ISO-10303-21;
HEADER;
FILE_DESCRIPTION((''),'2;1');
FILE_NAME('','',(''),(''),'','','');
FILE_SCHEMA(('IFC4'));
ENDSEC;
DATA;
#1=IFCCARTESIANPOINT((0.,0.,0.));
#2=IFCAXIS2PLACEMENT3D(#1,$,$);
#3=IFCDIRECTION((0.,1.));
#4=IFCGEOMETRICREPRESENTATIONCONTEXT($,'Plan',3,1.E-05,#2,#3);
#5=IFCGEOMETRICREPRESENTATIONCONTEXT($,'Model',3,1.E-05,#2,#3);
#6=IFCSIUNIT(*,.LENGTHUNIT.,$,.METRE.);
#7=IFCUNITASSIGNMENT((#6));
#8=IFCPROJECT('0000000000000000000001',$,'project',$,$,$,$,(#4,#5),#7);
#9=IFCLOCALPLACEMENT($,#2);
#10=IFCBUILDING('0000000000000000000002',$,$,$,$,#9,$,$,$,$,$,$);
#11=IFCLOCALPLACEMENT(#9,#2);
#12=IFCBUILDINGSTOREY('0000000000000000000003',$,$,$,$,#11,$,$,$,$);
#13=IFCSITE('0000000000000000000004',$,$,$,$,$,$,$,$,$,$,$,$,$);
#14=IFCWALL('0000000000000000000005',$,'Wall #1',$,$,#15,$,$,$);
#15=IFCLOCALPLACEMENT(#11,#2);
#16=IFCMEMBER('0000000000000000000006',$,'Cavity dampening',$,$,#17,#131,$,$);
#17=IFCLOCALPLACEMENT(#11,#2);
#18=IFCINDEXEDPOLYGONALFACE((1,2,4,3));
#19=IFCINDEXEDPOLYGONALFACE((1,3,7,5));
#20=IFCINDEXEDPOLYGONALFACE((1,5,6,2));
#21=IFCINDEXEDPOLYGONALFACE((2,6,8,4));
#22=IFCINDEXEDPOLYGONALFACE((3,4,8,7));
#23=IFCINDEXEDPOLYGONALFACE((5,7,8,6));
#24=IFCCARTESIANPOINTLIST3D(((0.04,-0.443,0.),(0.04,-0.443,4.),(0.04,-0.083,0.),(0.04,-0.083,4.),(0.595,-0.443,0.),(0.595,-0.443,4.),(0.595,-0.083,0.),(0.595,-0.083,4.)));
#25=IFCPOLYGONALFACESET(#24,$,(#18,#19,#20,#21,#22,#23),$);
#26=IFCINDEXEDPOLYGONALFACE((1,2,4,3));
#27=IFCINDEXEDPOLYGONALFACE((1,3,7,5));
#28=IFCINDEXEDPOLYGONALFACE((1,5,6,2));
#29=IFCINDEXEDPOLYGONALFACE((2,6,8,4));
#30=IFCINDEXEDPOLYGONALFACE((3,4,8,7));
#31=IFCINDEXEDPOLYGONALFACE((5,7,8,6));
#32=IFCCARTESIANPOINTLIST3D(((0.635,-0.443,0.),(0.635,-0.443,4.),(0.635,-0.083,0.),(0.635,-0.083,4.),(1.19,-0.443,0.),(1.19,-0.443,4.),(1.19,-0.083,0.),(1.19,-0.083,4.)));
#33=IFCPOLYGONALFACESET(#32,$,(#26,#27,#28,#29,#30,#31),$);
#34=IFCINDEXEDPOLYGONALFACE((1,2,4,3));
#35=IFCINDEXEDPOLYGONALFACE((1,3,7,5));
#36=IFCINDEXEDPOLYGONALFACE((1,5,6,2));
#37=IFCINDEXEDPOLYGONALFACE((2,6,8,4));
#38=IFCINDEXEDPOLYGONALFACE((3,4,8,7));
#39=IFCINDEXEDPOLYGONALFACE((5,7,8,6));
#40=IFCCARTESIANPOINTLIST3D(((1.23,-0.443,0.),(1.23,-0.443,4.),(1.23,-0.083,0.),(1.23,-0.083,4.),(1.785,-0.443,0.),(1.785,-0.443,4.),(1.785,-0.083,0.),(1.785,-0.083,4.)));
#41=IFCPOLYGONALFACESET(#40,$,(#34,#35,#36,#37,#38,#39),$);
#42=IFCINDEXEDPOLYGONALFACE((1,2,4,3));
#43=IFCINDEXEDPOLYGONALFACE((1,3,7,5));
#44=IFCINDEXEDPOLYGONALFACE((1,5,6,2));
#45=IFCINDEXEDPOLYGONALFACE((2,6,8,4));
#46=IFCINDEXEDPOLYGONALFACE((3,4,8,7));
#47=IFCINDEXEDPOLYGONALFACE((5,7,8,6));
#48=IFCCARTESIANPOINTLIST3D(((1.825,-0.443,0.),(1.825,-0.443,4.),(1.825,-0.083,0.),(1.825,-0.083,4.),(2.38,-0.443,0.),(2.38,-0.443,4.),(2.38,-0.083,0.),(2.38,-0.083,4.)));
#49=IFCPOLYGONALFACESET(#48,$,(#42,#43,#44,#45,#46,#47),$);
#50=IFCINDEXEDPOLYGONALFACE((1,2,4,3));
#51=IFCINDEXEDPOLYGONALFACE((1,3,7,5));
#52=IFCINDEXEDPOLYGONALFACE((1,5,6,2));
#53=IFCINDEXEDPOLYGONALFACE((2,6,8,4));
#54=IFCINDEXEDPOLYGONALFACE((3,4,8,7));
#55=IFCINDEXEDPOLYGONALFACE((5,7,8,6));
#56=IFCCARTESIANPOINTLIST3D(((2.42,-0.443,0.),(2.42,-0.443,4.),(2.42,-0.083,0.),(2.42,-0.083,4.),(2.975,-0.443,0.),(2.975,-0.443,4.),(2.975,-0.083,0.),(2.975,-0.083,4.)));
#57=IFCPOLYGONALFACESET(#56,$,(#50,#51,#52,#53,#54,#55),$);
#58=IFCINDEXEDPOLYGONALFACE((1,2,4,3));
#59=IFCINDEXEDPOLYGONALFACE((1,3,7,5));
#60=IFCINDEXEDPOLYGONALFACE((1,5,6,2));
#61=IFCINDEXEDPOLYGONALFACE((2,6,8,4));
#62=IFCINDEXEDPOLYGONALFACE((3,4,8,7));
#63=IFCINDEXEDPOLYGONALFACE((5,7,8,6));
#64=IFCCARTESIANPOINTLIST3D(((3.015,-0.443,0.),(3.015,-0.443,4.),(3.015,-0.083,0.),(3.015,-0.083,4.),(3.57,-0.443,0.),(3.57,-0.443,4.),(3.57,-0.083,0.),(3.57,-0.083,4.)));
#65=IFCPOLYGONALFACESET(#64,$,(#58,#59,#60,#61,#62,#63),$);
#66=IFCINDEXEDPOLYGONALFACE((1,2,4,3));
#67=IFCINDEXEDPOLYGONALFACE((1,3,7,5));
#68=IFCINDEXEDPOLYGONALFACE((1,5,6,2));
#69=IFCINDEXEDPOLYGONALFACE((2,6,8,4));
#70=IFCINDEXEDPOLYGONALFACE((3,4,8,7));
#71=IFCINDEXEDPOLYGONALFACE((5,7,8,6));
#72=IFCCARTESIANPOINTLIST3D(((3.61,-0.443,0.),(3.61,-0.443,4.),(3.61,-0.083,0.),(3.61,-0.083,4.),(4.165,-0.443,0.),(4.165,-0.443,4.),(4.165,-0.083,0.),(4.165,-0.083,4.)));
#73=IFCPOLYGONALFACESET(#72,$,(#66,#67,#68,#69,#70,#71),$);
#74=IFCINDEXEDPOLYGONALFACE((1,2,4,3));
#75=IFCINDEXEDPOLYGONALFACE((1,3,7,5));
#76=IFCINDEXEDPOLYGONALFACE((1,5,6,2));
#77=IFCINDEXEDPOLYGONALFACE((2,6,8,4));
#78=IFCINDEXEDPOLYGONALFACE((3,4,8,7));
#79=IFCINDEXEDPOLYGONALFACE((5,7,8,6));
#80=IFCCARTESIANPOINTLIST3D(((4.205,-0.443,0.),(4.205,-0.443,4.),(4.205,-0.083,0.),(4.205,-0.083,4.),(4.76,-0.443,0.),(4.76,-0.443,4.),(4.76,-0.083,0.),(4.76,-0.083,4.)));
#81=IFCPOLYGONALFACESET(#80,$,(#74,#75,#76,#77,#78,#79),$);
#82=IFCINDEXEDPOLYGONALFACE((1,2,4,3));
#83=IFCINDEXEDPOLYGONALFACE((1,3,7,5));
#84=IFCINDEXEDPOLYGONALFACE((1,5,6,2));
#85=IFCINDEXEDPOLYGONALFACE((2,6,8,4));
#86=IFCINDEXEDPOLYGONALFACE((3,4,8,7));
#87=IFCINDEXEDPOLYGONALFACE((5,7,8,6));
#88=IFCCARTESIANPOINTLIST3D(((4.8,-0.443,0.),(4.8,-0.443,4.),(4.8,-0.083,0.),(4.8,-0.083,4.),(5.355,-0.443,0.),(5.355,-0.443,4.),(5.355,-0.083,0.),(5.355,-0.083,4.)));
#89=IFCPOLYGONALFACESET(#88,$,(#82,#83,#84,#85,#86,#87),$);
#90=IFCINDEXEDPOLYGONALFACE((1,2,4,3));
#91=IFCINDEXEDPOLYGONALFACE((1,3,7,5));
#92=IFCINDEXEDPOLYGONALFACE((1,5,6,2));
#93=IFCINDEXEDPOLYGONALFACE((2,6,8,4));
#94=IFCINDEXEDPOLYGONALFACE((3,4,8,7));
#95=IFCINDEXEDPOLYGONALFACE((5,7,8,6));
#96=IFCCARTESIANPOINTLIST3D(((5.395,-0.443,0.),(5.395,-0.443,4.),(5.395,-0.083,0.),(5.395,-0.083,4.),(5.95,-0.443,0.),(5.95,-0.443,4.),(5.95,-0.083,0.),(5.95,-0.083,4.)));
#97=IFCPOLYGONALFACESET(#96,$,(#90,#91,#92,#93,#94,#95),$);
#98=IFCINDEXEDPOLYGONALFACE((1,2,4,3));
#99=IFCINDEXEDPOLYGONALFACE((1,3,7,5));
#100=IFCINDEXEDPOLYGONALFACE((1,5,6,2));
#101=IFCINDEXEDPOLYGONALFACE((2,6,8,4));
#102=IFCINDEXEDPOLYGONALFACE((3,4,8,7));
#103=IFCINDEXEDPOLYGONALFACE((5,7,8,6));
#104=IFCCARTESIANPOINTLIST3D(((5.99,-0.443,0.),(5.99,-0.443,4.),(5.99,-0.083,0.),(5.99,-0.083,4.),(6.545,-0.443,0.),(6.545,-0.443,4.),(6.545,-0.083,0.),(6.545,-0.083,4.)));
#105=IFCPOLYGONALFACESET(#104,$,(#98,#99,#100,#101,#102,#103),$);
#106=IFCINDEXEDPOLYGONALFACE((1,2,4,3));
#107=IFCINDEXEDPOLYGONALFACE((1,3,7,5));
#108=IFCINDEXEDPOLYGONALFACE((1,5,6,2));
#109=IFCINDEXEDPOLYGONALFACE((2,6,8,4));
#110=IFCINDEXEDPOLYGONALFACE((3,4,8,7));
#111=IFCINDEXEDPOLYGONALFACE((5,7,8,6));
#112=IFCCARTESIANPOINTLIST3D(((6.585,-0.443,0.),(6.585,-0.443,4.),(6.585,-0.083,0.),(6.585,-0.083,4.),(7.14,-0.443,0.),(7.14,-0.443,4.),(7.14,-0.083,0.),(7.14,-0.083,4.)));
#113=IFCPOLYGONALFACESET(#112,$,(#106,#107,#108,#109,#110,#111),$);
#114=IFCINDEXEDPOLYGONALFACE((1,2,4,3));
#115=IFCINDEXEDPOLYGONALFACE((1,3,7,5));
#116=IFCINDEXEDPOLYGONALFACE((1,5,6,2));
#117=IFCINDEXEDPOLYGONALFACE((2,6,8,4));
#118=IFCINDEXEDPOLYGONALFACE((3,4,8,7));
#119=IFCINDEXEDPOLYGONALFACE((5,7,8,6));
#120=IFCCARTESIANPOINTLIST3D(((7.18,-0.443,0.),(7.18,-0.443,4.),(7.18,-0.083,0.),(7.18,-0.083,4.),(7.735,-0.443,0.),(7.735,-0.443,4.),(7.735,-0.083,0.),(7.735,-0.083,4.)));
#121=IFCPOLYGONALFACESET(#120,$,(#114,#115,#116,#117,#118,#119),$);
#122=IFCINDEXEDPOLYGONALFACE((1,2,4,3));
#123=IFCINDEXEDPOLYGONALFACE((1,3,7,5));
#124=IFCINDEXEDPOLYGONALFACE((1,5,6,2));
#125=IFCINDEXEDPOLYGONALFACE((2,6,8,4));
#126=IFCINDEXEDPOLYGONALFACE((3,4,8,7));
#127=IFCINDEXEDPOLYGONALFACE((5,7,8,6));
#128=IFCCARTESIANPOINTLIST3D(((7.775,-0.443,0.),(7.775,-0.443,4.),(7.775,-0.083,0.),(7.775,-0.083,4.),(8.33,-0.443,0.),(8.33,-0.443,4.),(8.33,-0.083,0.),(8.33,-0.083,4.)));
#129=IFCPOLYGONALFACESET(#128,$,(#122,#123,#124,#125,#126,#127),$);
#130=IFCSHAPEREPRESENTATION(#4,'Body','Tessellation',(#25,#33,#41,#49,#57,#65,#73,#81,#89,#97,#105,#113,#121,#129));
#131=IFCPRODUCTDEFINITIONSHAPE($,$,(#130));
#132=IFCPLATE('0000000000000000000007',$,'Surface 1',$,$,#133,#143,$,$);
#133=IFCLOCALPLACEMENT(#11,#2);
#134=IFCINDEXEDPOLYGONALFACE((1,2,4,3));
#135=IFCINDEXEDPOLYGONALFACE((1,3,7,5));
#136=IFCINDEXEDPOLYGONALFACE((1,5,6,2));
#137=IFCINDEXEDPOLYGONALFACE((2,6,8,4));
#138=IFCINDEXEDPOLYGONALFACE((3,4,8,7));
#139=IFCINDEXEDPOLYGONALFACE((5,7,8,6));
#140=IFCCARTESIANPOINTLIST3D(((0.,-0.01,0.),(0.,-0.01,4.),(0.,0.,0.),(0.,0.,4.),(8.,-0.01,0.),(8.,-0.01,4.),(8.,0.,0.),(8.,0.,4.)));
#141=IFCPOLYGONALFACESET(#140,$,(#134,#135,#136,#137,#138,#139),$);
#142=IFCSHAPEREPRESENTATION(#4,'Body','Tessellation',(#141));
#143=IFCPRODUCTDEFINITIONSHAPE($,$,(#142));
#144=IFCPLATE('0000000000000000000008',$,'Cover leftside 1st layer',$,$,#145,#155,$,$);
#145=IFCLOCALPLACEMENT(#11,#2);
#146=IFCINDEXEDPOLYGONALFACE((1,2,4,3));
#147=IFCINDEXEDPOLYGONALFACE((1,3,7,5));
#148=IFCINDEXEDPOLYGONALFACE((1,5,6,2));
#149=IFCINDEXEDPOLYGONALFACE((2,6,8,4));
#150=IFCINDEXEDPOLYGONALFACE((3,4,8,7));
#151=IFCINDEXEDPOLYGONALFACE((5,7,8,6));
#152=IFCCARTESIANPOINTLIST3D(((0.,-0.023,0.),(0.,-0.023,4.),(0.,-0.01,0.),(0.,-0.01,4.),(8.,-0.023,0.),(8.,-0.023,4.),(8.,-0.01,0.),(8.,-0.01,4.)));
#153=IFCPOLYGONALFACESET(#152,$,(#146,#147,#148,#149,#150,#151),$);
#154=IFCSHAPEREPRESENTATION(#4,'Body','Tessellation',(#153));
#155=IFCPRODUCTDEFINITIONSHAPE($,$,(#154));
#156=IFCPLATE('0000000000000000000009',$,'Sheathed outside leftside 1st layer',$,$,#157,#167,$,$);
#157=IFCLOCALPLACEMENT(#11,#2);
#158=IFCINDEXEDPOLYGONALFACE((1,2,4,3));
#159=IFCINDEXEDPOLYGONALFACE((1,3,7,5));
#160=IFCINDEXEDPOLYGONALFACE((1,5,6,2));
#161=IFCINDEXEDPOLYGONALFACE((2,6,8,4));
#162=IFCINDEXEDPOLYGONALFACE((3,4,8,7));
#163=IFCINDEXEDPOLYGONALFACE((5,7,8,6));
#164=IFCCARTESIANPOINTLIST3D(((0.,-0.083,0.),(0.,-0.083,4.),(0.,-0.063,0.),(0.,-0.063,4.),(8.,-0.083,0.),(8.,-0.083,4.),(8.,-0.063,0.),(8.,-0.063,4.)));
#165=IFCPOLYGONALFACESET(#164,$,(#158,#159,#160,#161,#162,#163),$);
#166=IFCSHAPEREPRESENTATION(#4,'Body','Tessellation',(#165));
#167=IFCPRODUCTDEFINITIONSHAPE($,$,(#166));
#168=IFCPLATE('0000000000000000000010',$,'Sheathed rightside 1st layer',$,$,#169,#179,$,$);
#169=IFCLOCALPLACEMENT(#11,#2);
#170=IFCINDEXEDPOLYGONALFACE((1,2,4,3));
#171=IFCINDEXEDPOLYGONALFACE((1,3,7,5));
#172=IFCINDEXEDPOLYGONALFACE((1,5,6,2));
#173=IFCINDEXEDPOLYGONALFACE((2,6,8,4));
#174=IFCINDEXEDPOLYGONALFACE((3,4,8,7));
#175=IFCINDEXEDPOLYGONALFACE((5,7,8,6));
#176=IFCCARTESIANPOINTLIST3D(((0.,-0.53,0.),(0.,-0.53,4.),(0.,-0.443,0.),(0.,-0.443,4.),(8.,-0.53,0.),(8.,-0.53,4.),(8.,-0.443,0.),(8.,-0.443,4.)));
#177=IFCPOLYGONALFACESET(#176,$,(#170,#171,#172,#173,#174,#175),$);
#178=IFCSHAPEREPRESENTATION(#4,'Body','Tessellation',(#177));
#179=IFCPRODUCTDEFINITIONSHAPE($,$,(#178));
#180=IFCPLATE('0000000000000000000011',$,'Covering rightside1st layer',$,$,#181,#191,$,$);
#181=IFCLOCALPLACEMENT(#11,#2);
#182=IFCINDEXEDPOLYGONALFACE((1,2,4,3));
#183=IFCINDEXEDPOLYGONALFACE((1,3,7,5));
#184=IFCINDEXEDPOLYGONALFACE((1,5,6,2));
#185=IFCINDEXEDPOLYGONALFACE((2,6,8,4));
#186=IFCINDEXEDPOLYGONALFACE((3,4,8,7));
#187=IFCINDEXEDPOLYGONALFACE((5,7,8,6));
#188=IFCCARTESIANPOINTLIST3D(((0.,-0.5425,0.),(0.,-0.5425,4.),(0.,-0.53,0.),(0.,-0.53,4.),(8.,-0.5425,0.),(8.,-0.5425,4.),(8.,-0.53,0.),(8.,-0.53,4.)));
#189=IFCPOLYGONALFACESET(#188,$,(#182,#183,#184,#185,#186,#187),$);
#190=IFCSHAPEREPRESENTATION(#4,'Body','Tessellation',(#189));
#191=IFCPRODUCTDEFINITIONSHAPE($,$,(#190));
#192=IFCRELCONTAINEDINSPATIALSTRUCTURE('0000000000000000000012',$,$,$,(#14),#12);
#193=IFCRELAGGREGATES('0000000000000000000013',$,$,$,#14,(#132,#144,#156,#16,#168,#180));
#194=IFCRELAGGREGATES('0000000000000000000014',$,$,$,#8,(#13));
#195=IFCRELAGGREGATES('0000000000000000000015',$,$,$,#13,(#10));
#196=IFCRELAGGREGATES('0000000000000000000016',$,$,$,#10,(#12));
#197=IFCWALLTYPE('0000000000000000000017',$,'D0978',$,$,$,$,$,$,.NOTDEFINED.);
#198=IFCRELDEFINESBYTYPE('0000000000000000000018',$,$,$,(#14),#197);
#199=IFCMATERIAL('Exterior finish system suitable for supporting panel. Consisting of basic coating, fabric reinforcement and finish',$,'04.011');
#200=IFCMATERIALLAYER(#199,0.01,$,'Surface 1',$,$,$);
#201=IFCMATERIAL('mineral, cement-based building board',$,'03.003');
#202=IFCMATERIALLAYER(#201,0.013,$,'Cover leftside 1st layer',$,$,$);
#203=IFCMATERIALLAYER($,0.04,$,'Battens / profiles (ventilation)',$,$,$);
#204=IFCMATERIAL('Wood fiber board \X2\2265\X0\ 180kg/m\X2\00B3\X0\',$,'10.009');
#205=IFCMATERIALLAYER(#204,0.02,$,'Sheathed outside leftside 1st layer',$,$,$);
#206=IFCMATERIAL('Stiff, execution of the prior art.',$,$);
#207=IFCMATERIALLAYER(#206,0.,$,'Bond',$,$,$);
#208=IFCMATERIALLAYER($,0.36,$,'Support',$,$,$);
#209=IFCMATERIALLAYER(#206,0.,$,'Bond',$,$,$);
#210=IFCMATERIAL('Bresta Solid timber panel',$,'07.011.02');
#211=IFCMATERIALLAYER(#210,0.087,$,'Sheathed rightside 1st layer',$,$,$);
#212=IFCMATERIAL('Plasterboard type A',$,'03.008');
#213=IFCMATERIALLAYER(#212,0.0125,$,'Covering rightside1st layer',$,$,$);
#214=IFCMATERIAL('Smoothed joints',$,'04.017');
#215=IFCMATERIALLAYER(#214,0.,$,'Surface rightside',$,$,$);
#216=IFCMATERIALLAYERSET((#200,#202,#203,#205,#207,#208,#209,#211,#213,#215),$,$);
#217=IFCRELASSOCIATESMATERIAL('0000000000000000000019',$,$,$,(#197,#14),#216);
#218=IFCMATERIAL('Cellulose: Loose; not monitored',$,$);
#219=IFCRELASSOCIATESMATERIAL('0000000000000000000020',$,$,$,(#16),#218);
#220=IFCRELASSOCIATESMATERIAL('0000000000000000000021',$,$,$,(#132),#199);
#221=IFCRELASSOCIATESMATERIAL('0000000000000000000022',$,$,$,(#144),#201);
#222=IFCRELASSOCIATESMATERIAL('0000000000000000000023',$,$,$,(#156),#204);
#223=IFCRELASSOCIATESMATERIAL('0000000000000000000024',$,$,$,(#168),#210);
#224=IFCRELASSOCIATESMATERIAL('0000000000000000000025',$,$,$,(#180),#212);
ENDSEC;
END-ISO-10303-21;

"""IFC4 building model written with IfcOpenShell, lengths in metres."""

from ifc_helpers import new_model, si_unit, direction, frame, frame_2d, origin, origin_with_axes, place, context, project, spatial, rectangle, extrude, material, layer, layer_set, type_object, element, aggregate, save


model = new_model("IFC4")

# Units and contexts
plan_context = context("Plan", 3, precision=1e-05, world=origin(), true_north=direction((0.0, 1.0)))
model_context = context("Model", 3, precision=1e-05, world=origin(), true_north=direction((0.0, 1.0)))
ifc_project = project(units=[si_unit("LENGTHUNIT", "METRE")], contexts=[plan_context, model_context])

# Site, building, storey
site = spatial("IfcSite", under=ifc_project)
building_placement = place(None, origin())
building = spatial("IfcBuilding", under=site, at=building_placement)
storey_placement = place(building_placement, origin())
storey = spatial("IfcBuildingStorey", under=building, at=storey_placement)

# Wall, member, plates
ifc_material_1 = material(Name="Exterior finish system suitable for supporting panel. Consisting of basic coating, fabric reinforcement and finish", Category="04.011")
ifc_layer_1 = layer(ifc_material_1, 0.01, Name="Surface 1")
ifc_material_2 = material(Name="mineral, cement-based building board", Category="03.003")
ifc_layer_2 = layer(ifc_material_2, 0.013, Name="Cover leftside 1st layer")
ifc_layer_3 = layer(None, 0.04, Name="Battens / profiles (ventilation)")
ifc_material_3 = material(Name="Wood fiber board ≥ 180kg/m³", Category="10.009")
ifc_layer_4 = layer(ifc_material_3, 0.02, Name="Sheathed outside leftside 1st layer")
ifc_material_4 = material(Name="Stiff, execution of the prior art.")
ifc_layer_5 = layer(ifc_material_4, 0.0, Name="Bond")
ifc_layer_6 = layer(None, 0.36, Name="Support")
ifc_layer_7 = layer(ifc_material_4, 0.0, Name="Bond")
ifc_material_5 = material(Name="Bresta Solid timber panel", Category="07.011.02")
ifc_layer_8 = layer(ifc_material_5, 0.087, Name="Sheathed rightside 1st layer")
ifc_material_6 = material(Name="Plasterboard type A", Category="03.008")
ifc_layer_9 = layer(ifc_material_6, 0.0125, Name="Covering rightside1st layer")
ifc_material_7 = material(Name="Smoothed joints", Category="04.017")
ifc_layer_10 = layer(ifc_material_7, 0.0, Name="Surface rightside")
ifc_layer_set = layer_set([ifc_layer_1, ifc_layer_2, ifc_layer_3, ifc_layer_4, ifc_layer_5, ifc_layer_6, ifc_layer_7, ifc_layer_8, ifc_layer_9, ifc_layer_10])
wall_type = type_object("IfcWallType", Name="D0978", PredefinedType="NOTDEFINED", material=ifc_layer_set)
wall_placement = place(None, frame((0.0, 0.0, 0.0), z_axis=(0.0, -1.0, 0.0), x_axis=(1.0, 0.0, 0.0)))
wall = element("IfcWall", 1, at=wall_placement, inside=storey, type_object=wall_type, material=ifc_layer_set, Name="Wall #1")
ifc_material_8 = material(Name="Cellulose: Loose; not monitored")
member_1_placement = place(wall_placement, origin())
member_1 = element("IfcMember", 2, at=member_1_placement, material=ifc_material_8, Name="Cavity dampening", context=plan_context, shape_type="SweptSolid", body=[
    extrude(rectangle(XDim=0.555, YDim=0.36, at=frame_2d((0.2775, 0.18), x_axis=(1.0, 0.0))), frame((0.04, 4.0, 0.083), z_axis=(0.0, -1.0, 0.0), x_axis=(1.0, 0.0, 0.0)), (0.0, 0.0, 1.0), 4.0),
    extrude(rectangle(XDim=0.555, YDim=0.36, at=frame_2d((0.2775, 0.18), x_axis=(1.0, 0.0))), frame((0.635, 4.0, 0.083), z_axis=(0.0, -1.0, 0.0), x_axis=(1.0, 0.0, 0.0)), (0.0, 0.0, 1.0), 4.0),
    extrude(rectangle(XDim=0.555, YDim=0.36, at=frame_2d((0.2775, 0.18), x_axis=(1.0, 0.0))), frame((1.23, 4.0, 0.083), z_axis=(0.0, -1.0, 0.0), x_axis=(1.0, 0.0, 0.0)), (0.0, 0.0, 1.0), 4.0),
    extrude(rectangle(XDim=0.555, YDim=0.36, at=frame_2d((0.2775, 0.18), x_axis=(1.0, 0.0))), frame((1.825, 4.0, 0.083), z_axis=(0.0, -1.0, 0.0), x_axis=(1.0, 0.0, 0.0)), (0.0, 0.0, 1.0), 4.0),
    extrude(rectangle(XDim=0.555, YDim=0.36, at=frame_2d((0.2775, 0.18), x_axis=(1.0, 0.0))), frame((2.42, 4.0, 0.083), z_axis=(0.0, -1.0, 0.0), x_axis=(1.0, 0.0, 0.0)), (0.0, 0.0, 1.0), 4.0),
    extrude(rectangle(XDim=0.555, YDim=0.36, at=frame_2d((0.2775, 0.18), x_axis=(1.0, 0.0))), frame((3.015, 4.0, 0.083), z_axis=(0.0, -1.0, 0.0), x_axis=(1.0, 0.0, 0.0)), (0.0, 0.0, 1.0), 4.0),
    extrude(rectangle(XDim=0.555, YDim=0.36, at=frame_2d((0.2775, 0.18), x_axis=(1.0, 0.0))), frame((3.61, 4.0, 0.083), z_axis=(0.0, -1.0, 0.0), x_axis=(1.0, 0.0, 0.0)), (0.0, 0.0, 1.0), 4.0),
    extrude(rectangle(XDim=0.555, YDim=0.36, at=frame_2d((0.2775, 0.18), x_axis=(1.0, 0.0))), frame((4.205, 4.0, 0.083), z_axis=(0.0, -1.0, 0.0), x_axis=(1.0, 0.0, 0.0)), (0.0, 0.0, 1.0), 4.0),
    extrude(rectangle(XDim=0.555, YDim=0.36, at=frame_2d((0.2775, 0.18), x_axis=(1.0, 0.0))), frame((4.8, 4.0, 0.083), z_axis=(0.0, -1.0, 0.0), x_axis=(1.0, 0.0, 0.0)), (0.0, 0.0, 1.0), 4.0),
    extrude(rectangle(XDim=0.555, YDim=0.36, at=frame_2d((0.2775, 0.18), x_axis=(1.0, 0.0))), frame((5.395, 4.0, 0.083), z_axis=(0.0, -1.0, 0.0), x_axis=(1.0, 0.0, 0.0)), (0.0, 0.0, 1.0), 4.0),
    extrude(rectangle(XDim=0.555, YDim=0.36, at=frame_2d((0.2775, 0.18), x_axis=(1.0, 0.0))), frame((5.99, 4.0, 0.083), z_axis=(0.0, -1.0, 0.0), x_axis=(1.0, 0.0, 0.0)), (0.0, 0.0, 1.0), 4.0),
    extrude(rectangle(XDim=0.555, YDim=0.36, at=frame_2d((0.2775, 0.18), x_axis=(1.0, 0.0))), frame((6.585, 4.0, 0.083), z_axis=(0.0, -1.0, 0.0), x_axis=(1.0, 0.0, 0.0)), (0.0, 0.0, 1.0), 4.0),
    extrude(rectangle(XDim=0.555, YDim=0.36, at=frame_2d((0.2775, 0.18), x_axis=(1.0, 0.0))), frame((7.18, 4.0, 0.083), z_axis=(0.0, -1.0, 0.0), x_axis=(1.0, 0.0, 0.0)), (0.0, 0.0, 1.0), 4.0),
    extrude(rectangle(XDim=0.555, YDim=0.36, at=frame_2d((0.2775, 0.18), x_axis=(1.0, 0.0))), frame((7.775, 4.0, 0.083), z_axis=(0.0, -1.0, 0.0), x_axis=(1.0, 0.0, 0.0)), (0.0, 0.0, 1.0), 4.0),
])
plate_1_placement = place(wall_placement, origin())
plate_1 = element("IfcPlate", 3, at=plate_1_placement, material=ifc_material_1, Name="Surface 1", context=plan_context, shape_type="SweptSolid", body=[
    extrude(rectangle(XDim=8.0, YDim=4.0, at=frame_2d((4.0, 2.0), x_axis=(1.0, 0.0))), origin_with_axes(), (0.0, 0.0, 1.0), 0.01),
])
plate_2_placement = place(wall_placement, origin())
plate_2 = element("IfcPlate", 4, at=plate_2_placement, material=ifc_material_2, Name="Cover leftside 1st layer", context=plan_context, shape_type="SweptSolid", body=[
    extrude(rectangle(XDim=8.0, YDim=4.0, at=frame_2d((4.0, 2.0), x_axis=(1.0, 0.0))), frame((0.0, 0.0, 0.01), z_axis=(0.0, 0.0, 1.0), x_axis=(1.0, 0.0, 0.0)), (0.0, 0.0, 1.0), 0.013),
])
plate_3_placement = place(wall_placement, origin())
plate_3 = element("IfcPlate", 5, at=plate_3_placement, material=ifc_material_3, Name="Sheathed outside leftside 1st layer", context=plan_context, shape_type="SweptSolid", body=[
    extrude(rectangle(XDim=8.0, YDim=4.0, at=frame_2d((4.0, 2.0), x_axis=(1.0, 0.0))), frame((0.0, 0.0, 0.063), z_axis=(0.0, 0.0, 1.0), x_axis=(1.0, 0.0, 0.0)), (0.0, 0.0, 1.0), 0.02),
])
plate_4_placement = place(wall_placement, origin())
plate_4 = element("IfcPlate", 6, at=plate_4_placement, material=ifc_material_5, Name="Sheathed rightside 1st layer", context=plan_context, shape_type="SweptSolid", body=[
    extrude(rectangle(XDim=8.0, YDim=4.0, at=frame_2d((4.0, 2.0), x_axis=(1.0, 0.0))), frame((0.0, 0.0, 0.443), z_axis=(0.0, 0.0, 1.0), x_axis=(1.0, 0.0, 0.0)), (0.0, 0.0, 1.0), 0.087),
])
plate_5_placement = place(wall_placement, origin())
plate_5 = element("IfcPlate", 7, at=plate_5_placement, material=ifc_material_6, Name="Covering rightside1st layer", context=plan_context, shape_type="SweptSolid", body=[
    extrude(rectangle(XDim=8.0, YDim=4.0, at=frame_2d((4.0, 2.0), x_axis=(1.0, 0.0))), frame((0.0, 0.0, 0.53), z_axis=(0.0, 0.0, 1.0), x_axis=(1.0, 0.0, 0.0)), (0.0, 0.0, 1.0), 0.0125),
])
aggregate(wall, [plate_1, plate_2, plate_3, member_1, plate_4, plate_5])

save(model, "model.ifc")
